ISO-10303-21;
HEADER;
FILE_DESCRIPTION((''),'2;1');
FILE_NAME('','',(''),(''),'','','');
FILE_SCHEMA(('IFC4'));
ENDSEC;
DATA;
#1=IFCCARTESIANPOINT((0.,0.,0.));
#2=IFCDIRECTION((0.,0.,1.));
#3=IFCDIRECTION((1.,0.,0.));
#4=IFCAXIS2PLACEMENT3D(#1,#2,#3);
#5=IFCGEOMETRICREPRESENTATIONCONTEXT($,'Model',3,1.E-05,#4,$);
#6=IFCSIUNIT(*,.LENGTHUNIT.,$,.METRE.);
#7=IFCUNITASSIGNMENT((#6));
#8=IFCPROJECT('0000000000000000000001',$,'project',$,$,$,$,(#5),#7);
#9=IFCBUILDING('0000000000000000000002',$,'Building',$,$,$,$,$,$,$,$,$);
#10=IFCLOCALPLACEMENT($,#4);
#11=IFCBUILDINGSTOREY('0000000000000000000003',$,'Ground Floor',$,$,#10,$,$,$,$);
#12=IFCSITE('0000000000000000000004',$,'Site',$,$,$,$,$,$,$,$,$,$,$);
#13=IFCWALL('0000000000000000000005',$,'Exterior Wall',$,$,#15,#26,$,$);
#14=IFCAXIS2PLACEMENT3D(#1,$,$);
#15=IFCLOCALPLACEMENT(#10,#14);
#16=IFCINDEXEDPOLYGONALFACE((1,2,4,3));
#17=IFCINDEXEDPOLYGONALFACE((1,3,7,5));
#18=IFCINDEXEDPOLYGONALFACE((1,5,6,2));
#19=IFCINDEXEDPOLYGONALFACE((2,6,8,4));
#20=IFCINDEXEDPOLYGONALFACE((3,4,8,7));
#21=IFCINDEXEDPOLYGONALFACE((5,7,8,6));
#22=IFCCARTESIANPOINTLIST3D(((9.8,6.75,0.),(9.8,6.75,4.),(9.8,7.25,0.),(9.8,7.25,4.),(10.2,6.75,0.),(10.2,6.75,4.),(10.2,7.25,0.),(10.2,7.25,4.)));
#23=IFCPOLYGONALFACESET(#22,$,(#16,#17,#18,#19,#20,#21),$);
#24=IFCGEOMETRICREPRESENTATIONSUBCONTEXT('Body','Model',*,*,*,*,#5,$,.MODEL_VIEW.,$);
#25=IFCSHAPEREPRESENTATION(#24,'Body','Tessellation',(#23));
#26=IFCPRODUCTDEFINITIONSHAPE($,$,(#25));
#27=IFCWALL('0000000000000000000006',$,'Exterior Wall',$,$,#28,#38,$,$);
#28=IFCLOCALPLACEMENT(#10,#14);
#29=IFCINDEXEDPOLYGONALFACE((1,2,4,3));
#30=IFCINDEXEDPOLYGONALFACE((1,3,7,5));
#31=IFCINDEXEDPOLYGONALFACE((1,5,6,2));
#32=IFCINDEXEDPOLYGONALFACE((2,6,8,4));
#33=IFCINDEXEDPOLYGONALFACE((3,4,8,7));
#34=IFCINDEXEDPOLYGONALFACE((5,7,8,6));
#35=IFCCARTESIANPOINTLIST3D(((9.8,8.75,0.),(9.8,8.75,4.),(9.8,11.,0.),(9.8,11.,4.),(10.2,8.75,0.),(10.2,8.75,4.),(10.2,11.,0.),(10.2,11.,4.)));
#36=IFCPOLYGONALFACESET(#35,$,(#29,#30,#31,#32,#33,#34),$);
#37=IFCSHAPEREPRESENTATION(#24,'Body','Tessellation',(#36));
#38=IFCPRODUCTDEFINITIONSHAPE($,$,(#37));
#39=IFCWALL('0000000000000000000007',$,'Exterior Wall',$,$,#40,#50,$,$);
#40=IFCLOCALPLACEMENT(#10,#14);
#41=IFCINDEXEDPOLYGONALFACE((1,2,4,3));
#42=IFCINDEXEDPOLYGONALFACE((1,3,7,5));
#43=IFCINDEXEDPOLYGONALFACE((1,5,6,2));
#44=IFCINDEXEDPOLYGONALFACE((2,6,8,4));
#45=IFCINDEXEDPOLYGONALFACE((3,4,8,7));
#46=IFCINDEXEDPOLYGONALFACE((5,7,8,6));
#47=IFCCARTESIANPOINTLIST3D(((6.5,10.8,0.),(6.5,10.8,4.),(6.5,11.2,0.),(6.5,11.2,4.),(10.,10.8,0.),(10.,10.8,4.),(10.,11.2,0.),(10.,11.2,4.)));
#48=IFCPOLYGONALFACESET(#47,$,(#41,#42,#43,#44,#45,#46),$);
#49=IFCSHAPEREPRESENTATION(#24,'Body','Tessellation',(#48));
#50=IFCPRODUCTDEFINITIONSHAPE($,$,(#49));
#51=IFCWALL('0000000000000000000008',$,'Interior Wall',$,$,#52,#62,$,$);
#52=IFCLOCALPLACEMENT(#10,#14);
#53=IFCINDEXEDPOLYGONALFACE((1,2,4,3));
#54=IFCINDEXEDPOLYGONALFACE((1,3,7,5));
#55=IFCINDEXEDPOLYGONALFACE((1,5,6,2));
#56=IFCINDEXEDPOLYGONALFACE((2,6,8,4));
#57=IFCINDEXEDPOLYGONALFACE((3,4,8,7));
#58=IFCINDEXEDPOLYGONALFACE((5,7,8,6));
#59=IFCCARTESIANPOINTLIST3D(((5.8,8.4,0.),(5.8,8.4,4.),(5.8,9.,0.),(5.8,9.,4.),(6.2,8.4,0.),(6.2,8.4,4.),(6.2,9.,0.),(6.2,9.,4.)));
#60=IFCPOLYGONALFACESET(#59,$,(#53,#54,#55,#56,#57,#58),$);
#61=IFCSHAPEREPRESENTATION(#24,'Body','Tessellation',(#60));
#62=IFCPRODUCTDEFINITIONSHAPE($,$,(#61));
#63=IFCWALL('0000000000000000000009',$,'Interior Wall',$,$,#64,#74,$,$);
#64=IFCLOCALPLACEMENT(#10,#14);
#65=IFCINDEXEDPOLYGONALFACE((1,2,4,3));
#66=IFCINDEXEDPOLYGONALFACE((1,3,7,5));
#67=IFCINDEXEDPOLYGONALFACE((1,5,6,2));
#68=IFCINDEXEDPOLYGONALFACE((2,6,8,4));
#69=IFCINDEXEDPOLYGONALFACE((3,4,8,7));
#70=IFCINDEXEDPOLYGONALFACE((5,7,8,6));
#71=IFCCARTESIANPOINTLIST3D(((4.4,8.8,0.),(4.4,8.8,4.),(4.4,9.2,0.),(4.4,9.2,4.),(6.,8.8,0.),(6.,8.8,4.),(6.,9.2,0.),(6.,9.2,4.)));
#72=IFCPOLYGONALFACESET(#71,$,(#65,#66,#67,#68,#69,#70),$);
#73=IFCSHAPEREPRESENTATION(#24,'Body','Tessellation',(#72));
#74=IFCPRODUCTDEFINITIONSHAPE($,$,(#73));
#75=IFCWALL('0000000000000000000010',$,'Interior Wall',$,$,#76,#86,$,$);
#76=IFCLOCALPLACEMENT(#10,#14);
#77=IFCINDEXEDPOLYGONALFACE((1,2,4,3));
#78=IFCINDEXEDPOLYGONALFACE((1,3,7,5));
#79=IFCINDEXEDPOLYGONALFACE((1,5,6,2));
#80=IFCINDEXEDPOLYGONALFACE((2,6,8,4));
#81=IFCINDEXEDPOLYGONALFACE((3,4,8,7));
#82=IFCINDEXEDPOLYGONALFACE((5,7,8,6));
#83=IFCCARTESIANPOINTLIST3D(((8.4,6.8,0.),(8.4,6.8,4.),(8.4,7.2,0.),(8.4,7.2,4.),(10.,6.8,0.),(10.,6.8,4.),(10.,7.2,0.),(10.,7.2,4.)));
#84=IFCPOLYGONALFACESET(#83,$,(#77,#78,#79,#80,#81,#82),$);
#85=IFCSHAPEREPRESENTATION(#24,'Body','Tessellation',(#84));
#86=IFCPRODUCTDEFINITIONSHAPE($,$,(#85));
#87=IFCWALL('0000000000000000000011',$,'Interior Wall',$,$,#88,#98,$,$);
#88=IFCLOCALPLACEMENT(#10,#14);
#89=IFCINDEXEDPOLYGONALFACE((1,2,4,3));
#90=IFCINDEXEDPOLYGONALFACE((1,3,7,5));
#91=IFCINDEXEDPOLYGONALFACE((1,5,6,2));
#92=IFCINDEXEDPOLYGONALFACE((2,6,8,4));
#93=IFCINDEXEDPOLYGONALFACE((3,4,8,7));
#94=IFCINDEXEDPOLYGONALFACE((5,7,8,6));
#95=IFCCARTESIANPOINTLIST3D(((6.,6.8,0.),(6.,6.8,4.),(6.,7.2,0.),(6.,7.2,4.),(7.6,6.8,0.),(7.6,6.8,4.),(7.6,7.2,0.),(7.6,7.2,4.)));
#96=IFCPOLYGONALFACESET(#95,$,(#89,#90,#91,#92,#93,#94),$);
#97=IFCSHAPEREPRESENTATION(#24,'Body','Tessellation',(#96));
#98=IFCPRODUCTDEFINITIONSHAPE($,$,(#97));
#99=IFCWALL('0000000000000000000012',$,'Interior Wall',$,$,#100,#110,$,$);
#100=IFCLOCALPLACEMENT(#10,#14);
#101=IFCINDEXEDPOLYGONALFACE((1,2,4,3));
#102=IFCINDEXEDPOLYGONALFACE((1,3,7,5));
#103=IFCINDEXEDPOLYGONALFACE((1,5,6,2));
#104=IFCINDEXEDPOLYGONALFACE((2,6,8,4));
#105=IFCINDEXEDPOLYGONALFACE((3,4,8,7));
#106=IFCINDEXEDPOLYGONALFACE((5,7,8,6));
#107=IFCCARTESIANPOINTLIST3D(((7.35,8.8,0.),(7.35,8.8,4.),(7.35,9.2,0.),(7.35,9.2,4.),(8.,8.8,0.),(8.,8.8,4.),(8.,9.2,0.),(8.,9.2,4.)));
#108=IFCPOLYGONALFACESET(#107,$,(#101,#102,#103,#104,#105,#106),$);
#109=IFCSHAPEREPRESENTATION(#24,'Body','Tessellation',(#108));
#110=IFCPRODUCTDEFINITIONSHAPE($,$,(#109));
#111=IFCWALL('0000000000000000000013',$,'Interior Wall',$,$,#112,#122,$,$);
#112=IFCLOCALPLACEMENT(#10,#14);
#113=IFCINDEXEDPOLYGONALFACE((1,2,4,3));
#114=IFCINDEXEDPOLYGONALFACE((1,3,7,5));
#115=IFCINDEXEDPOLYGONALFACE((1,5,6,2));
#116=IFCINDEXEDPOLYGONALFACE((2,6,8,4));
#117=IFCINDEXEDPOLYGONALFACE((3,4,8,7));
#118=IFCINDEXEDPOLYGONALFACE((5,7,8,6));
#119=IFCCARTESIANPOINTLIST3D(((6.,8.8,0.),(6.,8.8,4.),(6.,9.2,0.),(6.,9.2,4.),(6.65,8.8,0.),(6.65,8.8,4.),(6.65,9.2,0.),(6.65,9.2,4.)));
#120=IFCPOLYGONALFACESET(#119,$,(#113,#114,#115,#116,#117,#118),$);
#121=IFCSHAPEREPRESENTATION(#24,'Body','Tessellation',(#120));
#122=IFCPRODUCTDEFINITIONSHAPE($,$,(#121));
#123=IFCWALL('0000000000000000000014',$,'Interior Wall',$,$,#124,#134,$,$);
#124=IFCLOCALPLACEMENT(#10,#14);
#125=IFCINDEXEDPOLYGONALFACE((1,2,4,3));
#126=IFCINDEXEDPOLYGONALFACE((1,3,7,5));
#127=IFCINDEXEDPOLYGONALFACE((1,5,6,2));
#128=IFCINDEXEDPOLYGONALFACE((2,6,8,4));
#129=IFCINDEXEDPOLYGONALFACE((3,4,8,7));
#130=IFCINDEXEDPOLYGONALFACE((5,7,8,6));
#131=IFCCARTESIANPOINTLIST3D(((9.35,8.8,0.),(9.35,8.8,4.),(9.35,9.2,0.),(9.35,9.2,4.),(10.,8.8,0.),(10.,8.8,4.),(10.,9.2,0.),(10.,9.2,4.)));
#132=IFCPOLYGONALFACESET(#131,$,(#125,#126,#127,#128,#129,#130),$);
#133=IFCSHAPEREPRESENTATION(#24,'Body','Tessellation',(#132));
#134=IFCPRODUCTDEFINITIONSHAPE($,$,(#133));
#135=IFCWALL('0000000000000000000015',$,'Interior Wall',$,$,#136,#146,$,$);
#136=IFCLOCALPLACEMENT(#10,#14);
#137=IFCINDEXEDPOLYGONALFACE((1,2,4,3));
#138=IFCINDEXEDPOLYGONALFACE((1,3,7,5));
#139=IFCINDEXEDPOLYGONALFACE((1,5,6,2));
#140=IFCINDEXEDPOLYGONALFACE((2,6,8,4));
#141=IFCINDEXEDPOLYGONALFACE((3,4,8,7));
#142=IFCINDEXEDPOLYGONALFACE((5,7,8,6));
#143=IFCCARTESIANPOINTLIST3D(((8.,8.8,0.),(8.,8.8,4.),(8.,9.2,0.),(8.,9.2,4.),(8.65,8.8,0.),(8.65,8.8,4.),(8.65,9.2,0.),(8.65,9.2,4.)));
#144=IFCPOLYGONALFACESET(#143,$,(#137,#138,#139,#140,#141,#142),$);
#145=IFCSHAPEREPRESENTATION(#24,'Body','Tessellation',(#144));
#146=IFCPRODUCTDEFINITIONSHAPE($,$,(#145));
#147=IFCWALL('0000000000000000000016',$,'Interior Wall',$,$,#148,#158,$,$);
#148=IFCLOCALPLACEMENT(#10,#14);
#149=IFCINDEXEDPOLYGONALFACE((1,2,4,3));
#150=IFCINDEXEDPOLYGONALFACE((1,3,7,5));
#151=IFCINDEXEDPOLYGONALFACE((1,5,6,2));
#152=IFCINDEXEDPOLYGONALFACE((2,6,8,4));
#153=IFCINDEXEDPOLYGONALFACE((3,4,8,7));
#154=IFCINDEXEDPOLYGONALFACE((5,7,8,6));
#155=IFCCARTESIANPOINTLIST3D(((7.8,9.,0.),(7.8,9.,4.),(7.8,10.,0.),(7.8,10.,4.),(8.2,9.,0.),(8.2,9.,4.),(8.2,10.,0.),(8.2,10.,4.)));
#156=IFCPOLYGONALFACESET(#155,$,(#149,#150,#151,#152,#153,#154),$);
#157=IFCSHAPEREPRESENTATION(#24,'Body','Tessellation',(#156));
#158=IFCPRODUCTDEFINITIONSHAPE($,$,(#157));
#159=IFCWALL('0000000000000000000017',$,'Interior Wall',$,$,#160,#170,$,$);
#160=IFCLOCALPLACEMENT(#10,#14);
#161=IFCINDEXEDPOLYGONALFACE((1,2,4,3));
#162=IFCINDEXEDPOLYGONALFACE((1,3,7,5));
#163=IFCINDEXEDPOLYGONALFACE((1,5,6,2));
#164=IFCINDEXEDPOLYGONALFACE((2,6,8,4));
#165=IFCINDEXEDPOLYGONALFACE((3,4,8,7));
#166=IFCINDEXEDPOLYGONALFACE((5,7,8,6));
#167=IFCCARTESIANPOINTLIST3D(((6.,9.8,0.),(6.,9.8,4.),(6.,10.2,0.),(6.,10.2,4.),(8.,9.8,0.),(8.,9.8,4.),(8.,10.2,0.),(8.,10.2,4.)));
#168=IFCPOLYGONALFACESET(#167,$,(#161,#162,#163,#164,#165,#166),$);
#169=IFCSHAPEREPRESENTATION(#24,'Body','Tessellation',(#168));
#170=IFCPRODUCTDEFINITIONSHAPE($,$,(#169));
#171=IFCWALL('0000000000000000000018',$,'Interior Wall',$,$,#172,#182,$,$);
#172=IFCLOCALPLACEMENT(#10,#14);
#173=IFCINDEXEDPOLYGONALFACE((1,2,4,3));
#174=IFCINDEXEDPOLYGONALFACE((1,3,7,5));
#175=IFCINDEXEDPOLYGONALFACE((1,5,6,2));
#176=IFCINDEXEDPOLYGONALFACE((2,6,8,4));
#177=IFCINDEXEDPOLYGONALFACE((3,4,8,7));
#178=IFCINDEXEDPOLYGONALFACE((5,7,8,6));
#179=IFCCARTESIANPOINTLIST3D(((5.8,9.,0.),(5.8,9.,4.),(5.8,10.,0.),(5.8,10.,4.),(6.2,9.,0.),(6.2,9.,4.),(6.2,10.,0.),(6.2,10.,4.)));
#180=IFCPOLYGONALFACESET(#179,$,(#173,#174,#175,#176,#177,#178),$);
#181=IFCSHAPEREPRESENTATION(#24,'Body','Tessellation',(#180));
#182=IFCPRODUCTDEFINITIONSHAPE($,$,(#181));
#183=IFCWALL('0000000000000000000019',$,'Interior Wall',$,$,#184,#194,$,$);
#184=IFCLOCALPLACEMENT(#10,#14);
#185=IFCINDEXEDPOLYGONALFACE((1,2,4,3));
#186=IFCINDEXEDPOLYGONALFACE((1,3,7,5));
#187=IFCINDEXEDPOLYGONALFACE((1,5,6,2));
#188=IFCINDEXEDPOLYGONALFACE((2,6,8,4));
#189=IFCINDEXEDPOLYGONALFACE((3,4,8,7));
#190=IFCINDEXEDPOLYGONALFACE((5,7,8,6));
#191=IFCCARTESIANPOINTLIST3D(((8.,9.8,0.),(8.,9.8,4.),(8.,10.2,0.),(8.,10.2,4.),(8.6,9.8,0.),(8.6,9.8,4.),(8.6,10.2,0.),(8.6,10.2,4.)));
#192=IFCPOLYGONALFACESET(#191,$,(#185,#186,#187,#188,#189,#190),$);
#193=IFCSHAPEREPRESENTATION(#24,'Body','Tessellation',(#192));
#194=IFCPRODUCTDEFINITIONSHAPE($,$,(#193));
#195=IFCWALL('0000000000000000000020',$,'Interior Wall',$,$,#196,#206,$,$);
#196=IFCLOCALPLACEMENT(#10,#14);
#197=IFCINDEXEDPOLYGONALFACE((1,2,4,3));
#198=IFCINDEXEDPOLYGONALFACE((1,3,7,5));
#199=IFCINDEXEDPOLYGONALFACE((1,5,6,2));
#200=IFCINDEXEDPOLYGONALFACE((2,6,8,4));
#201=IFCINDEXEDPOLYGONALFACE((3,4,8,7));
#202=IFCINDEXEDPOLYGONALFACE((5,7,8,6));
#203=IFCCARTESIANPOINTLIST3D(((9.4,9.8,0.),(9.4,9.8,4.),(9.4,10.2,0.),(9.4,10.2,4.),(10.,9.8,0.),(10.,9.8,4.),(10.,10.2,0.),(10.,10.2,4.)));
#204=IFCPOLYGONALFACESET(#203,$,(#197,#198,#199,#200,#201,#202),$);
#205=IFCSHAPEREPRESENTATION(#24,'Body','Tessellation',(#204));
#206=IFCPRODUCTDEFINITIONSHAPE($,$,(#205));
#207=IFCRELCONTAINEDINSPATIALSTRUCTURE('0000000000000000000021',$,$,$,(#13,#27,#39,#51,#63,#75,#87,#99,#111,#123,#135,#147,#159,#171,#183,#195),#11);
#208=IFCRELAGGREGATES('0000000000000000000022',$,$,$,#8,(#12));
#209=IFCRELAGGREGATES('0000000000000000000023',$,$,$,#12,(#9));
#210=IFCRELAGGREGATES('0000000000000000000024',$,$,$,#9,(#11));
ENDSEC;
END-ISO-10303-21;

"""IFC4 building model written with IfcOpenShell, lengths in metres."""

from ifc_helpers import new_model, si_unit, frame, origin_with_axes, place, context, subcontext, project, spatial, indexed_curve, outline, extrude, element, save


model = new_model("IFC4")

# Units and contexts
model_context = context("Model", 3, precision=1e-05, world=origin_with_axes())
body_context = subcontext(model_context, "Body", "Model", "MODEL_VIEW")
ifc_project = project(units=[si_unit("LENGTHUNIT", "METRE")], contexts=[model_context])

# Site, building, storey
site = spatial("IfcSite", under=ifc_project, Name="Site")
building = spatial("IfcBuilding", under=site, Name="Building")
storey_placement = place(None, origin_with_axes())
storey = spatial("IfcBuildingStorey", under=building, at=storey_placement, Name="Ground Floor")

# Walls
wall_1_placement = place(storey_placement, frame((10.0, 6.75, 0.0), z_axis=(0.0, 0.0, 1.0), x_axis=(0.0, 1.0, 0.0)))
element("IfcWall", 1, at=wall_1_placement, inside=storey, Name="Exterior Wall", context=body_context, shape_type="SweptSolid", body=[
    extrude(outline(indexed_curve([(0.0, 0.0), (0.0, 0.4), (0.5, 0.4), (0.5, 0.0), (0.0, 0.0)], self_intersect=False)), frame((0.0, -0.2, 0.0), z_axis=(0.0, 0.0, 1.0), x_axis=(1.0, 0.0, 0.0)), (0.0, 0.0, 1.0), 4.0),
])
wall_2_placement = place(storey_placement, frame((10.0, 8.75, 0.0), z_axis=(0.0, 0.0, 1.0), x_axis=(0.0, 1.0, 0.0)))
element("IfcWall", 2, at=wall_2_placement, inside=storey, Name="Exterior Wall", context=body_context, shape_type="SweptSolid", body=[
    extrude(outline(indexed_curve([(0.0, 0.0), (0.0, 0.4), (2.25, 0.4), (2.25, 0.0), (0.0, 0.0)], self_intersect=False)), frame((0.0, -0.2, 0.0), z_axis=(0.0, 0.0, 1.0), x_axis=(1.0, 0.0, 0.0)), (0.0, 0.0, 1.0), 4.0),
])
wall_3_placement = place(storey_placement, frame((10.0, 11.0, 0.0), z_axis=(0.0, 0.0, 1.0), x_axis=(-1.0, 0.0, 0.0)))
element("IfcWall", 3, at=wall_3_placement, inside=storey, Name="Exterior Wall", context=body_context, shape_type="SweptSolid", body=[
    extrude(outline(indexed_curve([(0.0, 0.0), (0.0, 0.4), (3.5, 0.4), (3.5, 0.0), (0.0, 0.0)], self_intersect=False)), frame((0.0, -0.2, 0.0), z_axis=(0.0, 0.0, 1.0), x_axis=(1.0, 0.0, 0.0)), (0.0, 0.0, 1.0), 4.0),
])
wall_4_placement = place(storey_placement, frame((6.0, 8.4, 0.0), z_axis=(0.0, 0.0, 1.0), x_axis=(0.0, 1.0, 0.0)))
element("IfcWall", 4, at=wall_4_placement, inside=storey, Name="Interior Wall", context=body_context, shape_type="SweptSolid", body=[
    extrude(outline(indexed_curve([(0.0, 0.0), (0.0, 0.4), (0.6, 0.4), (0.6, 0.0), (0.0, 0.0)], self_intersect=False)), frame((0.0, -0.2, 0.0), z_axis=(0.0, 0.0, 1.0), x_axis=(1.0, 0.0, 0.0)), (0.0, 0.0, 1.0), 4.0),
])
for number, where, z_axis, x_axis, name in (
    (5, (6.0, 9.0, 0.0), (0.0, 0.0, 1.0), (-1.0, 0.0, 0.0), "Interior Wall"),
    (6, (10.0, 7.0, 0.0), (0.0, 0.0, 1.0), (-1.0, 0.0, 0.0), "Interior Wall"),
    (7, (7.6, 7.0, 0.0), (0.0, 0.0, 1.0), (-1.0, 0.0, 0.0), "Interior Wall"),
):
    element("IfcWall", number, at=place(storey_placement, frame(where, z_axis=z_axis, x_axis=x_axis)), inside=storey, Name=name, context=body_context, shape_type="SweptSolid", body=[
        extrude(outline(indexed_curve([(0.0, 0.0), (0.0, 0.4), (1.6, 0.4), (1.6, 0.0), (0.0, 0.0)], self_intersect=False)), frame((0.0, -0.2, 0.0), z_axis=(0.0, 0.0, 1.0), x_axis=(1.0, 0.0, 0.0)), (0.0, 0.0, 1.0), 4.0),
    ])
for number, where, z_axis, x_axis, name in (
    (8, (8.0, 9.0, 0.0), (0.0, 0.0, 1.0), (-1.0, 0.0, 0.0), "Interior Wall"),
    (9, (6.65, 9.0, 0.0), (0.0, 0.0, 1.0), (-1.0, 0.0, 0.0), "Interior Wall"),
    (10, (10.0, 9.0, 0.0), (0.0, 0.0, 1.0), (-1.0, 0.0, 0.0), "Interior Wall"),
    (11, (8.65, 9.0, 0.0), (0.0, 0.0, 1.0), (-1.0, 0.0, 0.0), "Interior Wall"),
):
    element("IfcWall", number, at=place(storey_placement, frame(where, z_axis=z_axis, x_axis=x_axis)), inside=storey, Name=name, context=body_context, shape_type="SweptSolid", body=[
        extrude(outline(indexed_curve([(0.0, 0.0), (0.0, 0.4), (0.65, 0.4), (0.65, 0.0), (0.0, 0.0)], self_intersect=False)), frame((0.0, -0.2, 0.0), z_axis=(0.0, 0.0, 1.0), x_axis=(1.0, 0.0, 0.0)), (0.0, 0.0, 1.0), 4.0),
    ])
wall_5_placement = place(storey_placement, frame((8.0, 9.0, 0.0), z_axis=(0.0, 0.0, 1.0), x_axis=(0.0, 1.0, 0.0)))
element("IfcWall", 12, at=wall_5_placement, inside=storey, Name="Interior Wall", context=body_context, shape_type="SweptSolid", body=[
    extrude(outline(indexed_curve([(0.0, 0.0), (0.0, 0.4), (1.0, 0.4), (1.0, 0.0), (0.0, 0.0)], self_intersect=False)), frame((0.0, -0.2, 0.0), z_axis=(0.0, 0.0, 1.0), x_axis=(1.0, 0.0, 0.0)), (0.0, 0.0, 1.0), 4.0),
])
wall_6_placement = place(storey_placement, frame((8.0, 10.0, 0.0), z_axis=(0.0, 0.0, 1.0), x_axis=(-1.0, 0.0, 0.0)))
element("IfcWall", 13, at=wall_6_placement, inside=storey, Name="Interior Wall", context=body_context, shape_type="SweptSolid", body=[
    extrude(outline(indexed_curve([(0.0, 0.0), (0.0, 0.4), (2.0, 0.4), (2.0, 0.0), (0.0, 0.0)], self_intersect=False)), frame((0.0, -0.2, 0.0), z_axis=(0.0, 0.0, 1.0), x_axis=(1.0, 0.0, 0.0)), (0.0, 0.0, 1.0), 4.0),
])
wall_7_placement = place(storey_placement, frame((6.0, 10.0, 0.0), z_axis=(0.0, 0.0, 1.0), x_axis=(0.0, -1.0, 0.0)))
element("IfcWall", 14, at=wall_7_placement, inside=storey, Name="Interior Wall", context=body_context, shape_type="SweptSolid", body=[
    extrude(outline(indexed_curve([(0.0, 0.0), (0.0, 0.4), (1.0, 0.4), (1.0, 0.0), (0.0, 0.0)], self_intersect=False)), frame((0.0, -0.2, 0.0), z_axis=(0.0, 0.0, 1.0), x_axis=(1.0, 0.0, 0.0)), (0.0, 0.0, 1.0), 4.0),
])
for number, where, z_axis, x_axis, name in (
    (15, (8.0, 10.0, 0.0), (0.0, 0.0, 1.0), (1.0, 0.0, 0.0), "Interior Wall"),
    (16, (9.4, 10.0, 0.0), (0.0, 0.0, 1.0), (1.0, 0.0, 0.0), "Interior Wall"),
):
    element("IfcWall", number, at=place(storey_placement, frame(where, z_axis=z_axis, x_axis=x_axis)), inside=storey, Name=name, context=body_context, shape_type="SweptSolid", body=[
        extrude(outline(indexed_curve([(0.0, 0.0), (0.0, 0.4), (0.6, 0.4), (0.6, 0.0), (0.0, 0.0)], self_intersect=False)), frame((0.0, -0.2, 0.0), z_axis=(0.0, 0.0, 1.0), x_axis=(1.0, 0.0, 0.0)), (0.0, 0.0, 1.0), 4.0),
    ])

save(model, "model.ifc")
